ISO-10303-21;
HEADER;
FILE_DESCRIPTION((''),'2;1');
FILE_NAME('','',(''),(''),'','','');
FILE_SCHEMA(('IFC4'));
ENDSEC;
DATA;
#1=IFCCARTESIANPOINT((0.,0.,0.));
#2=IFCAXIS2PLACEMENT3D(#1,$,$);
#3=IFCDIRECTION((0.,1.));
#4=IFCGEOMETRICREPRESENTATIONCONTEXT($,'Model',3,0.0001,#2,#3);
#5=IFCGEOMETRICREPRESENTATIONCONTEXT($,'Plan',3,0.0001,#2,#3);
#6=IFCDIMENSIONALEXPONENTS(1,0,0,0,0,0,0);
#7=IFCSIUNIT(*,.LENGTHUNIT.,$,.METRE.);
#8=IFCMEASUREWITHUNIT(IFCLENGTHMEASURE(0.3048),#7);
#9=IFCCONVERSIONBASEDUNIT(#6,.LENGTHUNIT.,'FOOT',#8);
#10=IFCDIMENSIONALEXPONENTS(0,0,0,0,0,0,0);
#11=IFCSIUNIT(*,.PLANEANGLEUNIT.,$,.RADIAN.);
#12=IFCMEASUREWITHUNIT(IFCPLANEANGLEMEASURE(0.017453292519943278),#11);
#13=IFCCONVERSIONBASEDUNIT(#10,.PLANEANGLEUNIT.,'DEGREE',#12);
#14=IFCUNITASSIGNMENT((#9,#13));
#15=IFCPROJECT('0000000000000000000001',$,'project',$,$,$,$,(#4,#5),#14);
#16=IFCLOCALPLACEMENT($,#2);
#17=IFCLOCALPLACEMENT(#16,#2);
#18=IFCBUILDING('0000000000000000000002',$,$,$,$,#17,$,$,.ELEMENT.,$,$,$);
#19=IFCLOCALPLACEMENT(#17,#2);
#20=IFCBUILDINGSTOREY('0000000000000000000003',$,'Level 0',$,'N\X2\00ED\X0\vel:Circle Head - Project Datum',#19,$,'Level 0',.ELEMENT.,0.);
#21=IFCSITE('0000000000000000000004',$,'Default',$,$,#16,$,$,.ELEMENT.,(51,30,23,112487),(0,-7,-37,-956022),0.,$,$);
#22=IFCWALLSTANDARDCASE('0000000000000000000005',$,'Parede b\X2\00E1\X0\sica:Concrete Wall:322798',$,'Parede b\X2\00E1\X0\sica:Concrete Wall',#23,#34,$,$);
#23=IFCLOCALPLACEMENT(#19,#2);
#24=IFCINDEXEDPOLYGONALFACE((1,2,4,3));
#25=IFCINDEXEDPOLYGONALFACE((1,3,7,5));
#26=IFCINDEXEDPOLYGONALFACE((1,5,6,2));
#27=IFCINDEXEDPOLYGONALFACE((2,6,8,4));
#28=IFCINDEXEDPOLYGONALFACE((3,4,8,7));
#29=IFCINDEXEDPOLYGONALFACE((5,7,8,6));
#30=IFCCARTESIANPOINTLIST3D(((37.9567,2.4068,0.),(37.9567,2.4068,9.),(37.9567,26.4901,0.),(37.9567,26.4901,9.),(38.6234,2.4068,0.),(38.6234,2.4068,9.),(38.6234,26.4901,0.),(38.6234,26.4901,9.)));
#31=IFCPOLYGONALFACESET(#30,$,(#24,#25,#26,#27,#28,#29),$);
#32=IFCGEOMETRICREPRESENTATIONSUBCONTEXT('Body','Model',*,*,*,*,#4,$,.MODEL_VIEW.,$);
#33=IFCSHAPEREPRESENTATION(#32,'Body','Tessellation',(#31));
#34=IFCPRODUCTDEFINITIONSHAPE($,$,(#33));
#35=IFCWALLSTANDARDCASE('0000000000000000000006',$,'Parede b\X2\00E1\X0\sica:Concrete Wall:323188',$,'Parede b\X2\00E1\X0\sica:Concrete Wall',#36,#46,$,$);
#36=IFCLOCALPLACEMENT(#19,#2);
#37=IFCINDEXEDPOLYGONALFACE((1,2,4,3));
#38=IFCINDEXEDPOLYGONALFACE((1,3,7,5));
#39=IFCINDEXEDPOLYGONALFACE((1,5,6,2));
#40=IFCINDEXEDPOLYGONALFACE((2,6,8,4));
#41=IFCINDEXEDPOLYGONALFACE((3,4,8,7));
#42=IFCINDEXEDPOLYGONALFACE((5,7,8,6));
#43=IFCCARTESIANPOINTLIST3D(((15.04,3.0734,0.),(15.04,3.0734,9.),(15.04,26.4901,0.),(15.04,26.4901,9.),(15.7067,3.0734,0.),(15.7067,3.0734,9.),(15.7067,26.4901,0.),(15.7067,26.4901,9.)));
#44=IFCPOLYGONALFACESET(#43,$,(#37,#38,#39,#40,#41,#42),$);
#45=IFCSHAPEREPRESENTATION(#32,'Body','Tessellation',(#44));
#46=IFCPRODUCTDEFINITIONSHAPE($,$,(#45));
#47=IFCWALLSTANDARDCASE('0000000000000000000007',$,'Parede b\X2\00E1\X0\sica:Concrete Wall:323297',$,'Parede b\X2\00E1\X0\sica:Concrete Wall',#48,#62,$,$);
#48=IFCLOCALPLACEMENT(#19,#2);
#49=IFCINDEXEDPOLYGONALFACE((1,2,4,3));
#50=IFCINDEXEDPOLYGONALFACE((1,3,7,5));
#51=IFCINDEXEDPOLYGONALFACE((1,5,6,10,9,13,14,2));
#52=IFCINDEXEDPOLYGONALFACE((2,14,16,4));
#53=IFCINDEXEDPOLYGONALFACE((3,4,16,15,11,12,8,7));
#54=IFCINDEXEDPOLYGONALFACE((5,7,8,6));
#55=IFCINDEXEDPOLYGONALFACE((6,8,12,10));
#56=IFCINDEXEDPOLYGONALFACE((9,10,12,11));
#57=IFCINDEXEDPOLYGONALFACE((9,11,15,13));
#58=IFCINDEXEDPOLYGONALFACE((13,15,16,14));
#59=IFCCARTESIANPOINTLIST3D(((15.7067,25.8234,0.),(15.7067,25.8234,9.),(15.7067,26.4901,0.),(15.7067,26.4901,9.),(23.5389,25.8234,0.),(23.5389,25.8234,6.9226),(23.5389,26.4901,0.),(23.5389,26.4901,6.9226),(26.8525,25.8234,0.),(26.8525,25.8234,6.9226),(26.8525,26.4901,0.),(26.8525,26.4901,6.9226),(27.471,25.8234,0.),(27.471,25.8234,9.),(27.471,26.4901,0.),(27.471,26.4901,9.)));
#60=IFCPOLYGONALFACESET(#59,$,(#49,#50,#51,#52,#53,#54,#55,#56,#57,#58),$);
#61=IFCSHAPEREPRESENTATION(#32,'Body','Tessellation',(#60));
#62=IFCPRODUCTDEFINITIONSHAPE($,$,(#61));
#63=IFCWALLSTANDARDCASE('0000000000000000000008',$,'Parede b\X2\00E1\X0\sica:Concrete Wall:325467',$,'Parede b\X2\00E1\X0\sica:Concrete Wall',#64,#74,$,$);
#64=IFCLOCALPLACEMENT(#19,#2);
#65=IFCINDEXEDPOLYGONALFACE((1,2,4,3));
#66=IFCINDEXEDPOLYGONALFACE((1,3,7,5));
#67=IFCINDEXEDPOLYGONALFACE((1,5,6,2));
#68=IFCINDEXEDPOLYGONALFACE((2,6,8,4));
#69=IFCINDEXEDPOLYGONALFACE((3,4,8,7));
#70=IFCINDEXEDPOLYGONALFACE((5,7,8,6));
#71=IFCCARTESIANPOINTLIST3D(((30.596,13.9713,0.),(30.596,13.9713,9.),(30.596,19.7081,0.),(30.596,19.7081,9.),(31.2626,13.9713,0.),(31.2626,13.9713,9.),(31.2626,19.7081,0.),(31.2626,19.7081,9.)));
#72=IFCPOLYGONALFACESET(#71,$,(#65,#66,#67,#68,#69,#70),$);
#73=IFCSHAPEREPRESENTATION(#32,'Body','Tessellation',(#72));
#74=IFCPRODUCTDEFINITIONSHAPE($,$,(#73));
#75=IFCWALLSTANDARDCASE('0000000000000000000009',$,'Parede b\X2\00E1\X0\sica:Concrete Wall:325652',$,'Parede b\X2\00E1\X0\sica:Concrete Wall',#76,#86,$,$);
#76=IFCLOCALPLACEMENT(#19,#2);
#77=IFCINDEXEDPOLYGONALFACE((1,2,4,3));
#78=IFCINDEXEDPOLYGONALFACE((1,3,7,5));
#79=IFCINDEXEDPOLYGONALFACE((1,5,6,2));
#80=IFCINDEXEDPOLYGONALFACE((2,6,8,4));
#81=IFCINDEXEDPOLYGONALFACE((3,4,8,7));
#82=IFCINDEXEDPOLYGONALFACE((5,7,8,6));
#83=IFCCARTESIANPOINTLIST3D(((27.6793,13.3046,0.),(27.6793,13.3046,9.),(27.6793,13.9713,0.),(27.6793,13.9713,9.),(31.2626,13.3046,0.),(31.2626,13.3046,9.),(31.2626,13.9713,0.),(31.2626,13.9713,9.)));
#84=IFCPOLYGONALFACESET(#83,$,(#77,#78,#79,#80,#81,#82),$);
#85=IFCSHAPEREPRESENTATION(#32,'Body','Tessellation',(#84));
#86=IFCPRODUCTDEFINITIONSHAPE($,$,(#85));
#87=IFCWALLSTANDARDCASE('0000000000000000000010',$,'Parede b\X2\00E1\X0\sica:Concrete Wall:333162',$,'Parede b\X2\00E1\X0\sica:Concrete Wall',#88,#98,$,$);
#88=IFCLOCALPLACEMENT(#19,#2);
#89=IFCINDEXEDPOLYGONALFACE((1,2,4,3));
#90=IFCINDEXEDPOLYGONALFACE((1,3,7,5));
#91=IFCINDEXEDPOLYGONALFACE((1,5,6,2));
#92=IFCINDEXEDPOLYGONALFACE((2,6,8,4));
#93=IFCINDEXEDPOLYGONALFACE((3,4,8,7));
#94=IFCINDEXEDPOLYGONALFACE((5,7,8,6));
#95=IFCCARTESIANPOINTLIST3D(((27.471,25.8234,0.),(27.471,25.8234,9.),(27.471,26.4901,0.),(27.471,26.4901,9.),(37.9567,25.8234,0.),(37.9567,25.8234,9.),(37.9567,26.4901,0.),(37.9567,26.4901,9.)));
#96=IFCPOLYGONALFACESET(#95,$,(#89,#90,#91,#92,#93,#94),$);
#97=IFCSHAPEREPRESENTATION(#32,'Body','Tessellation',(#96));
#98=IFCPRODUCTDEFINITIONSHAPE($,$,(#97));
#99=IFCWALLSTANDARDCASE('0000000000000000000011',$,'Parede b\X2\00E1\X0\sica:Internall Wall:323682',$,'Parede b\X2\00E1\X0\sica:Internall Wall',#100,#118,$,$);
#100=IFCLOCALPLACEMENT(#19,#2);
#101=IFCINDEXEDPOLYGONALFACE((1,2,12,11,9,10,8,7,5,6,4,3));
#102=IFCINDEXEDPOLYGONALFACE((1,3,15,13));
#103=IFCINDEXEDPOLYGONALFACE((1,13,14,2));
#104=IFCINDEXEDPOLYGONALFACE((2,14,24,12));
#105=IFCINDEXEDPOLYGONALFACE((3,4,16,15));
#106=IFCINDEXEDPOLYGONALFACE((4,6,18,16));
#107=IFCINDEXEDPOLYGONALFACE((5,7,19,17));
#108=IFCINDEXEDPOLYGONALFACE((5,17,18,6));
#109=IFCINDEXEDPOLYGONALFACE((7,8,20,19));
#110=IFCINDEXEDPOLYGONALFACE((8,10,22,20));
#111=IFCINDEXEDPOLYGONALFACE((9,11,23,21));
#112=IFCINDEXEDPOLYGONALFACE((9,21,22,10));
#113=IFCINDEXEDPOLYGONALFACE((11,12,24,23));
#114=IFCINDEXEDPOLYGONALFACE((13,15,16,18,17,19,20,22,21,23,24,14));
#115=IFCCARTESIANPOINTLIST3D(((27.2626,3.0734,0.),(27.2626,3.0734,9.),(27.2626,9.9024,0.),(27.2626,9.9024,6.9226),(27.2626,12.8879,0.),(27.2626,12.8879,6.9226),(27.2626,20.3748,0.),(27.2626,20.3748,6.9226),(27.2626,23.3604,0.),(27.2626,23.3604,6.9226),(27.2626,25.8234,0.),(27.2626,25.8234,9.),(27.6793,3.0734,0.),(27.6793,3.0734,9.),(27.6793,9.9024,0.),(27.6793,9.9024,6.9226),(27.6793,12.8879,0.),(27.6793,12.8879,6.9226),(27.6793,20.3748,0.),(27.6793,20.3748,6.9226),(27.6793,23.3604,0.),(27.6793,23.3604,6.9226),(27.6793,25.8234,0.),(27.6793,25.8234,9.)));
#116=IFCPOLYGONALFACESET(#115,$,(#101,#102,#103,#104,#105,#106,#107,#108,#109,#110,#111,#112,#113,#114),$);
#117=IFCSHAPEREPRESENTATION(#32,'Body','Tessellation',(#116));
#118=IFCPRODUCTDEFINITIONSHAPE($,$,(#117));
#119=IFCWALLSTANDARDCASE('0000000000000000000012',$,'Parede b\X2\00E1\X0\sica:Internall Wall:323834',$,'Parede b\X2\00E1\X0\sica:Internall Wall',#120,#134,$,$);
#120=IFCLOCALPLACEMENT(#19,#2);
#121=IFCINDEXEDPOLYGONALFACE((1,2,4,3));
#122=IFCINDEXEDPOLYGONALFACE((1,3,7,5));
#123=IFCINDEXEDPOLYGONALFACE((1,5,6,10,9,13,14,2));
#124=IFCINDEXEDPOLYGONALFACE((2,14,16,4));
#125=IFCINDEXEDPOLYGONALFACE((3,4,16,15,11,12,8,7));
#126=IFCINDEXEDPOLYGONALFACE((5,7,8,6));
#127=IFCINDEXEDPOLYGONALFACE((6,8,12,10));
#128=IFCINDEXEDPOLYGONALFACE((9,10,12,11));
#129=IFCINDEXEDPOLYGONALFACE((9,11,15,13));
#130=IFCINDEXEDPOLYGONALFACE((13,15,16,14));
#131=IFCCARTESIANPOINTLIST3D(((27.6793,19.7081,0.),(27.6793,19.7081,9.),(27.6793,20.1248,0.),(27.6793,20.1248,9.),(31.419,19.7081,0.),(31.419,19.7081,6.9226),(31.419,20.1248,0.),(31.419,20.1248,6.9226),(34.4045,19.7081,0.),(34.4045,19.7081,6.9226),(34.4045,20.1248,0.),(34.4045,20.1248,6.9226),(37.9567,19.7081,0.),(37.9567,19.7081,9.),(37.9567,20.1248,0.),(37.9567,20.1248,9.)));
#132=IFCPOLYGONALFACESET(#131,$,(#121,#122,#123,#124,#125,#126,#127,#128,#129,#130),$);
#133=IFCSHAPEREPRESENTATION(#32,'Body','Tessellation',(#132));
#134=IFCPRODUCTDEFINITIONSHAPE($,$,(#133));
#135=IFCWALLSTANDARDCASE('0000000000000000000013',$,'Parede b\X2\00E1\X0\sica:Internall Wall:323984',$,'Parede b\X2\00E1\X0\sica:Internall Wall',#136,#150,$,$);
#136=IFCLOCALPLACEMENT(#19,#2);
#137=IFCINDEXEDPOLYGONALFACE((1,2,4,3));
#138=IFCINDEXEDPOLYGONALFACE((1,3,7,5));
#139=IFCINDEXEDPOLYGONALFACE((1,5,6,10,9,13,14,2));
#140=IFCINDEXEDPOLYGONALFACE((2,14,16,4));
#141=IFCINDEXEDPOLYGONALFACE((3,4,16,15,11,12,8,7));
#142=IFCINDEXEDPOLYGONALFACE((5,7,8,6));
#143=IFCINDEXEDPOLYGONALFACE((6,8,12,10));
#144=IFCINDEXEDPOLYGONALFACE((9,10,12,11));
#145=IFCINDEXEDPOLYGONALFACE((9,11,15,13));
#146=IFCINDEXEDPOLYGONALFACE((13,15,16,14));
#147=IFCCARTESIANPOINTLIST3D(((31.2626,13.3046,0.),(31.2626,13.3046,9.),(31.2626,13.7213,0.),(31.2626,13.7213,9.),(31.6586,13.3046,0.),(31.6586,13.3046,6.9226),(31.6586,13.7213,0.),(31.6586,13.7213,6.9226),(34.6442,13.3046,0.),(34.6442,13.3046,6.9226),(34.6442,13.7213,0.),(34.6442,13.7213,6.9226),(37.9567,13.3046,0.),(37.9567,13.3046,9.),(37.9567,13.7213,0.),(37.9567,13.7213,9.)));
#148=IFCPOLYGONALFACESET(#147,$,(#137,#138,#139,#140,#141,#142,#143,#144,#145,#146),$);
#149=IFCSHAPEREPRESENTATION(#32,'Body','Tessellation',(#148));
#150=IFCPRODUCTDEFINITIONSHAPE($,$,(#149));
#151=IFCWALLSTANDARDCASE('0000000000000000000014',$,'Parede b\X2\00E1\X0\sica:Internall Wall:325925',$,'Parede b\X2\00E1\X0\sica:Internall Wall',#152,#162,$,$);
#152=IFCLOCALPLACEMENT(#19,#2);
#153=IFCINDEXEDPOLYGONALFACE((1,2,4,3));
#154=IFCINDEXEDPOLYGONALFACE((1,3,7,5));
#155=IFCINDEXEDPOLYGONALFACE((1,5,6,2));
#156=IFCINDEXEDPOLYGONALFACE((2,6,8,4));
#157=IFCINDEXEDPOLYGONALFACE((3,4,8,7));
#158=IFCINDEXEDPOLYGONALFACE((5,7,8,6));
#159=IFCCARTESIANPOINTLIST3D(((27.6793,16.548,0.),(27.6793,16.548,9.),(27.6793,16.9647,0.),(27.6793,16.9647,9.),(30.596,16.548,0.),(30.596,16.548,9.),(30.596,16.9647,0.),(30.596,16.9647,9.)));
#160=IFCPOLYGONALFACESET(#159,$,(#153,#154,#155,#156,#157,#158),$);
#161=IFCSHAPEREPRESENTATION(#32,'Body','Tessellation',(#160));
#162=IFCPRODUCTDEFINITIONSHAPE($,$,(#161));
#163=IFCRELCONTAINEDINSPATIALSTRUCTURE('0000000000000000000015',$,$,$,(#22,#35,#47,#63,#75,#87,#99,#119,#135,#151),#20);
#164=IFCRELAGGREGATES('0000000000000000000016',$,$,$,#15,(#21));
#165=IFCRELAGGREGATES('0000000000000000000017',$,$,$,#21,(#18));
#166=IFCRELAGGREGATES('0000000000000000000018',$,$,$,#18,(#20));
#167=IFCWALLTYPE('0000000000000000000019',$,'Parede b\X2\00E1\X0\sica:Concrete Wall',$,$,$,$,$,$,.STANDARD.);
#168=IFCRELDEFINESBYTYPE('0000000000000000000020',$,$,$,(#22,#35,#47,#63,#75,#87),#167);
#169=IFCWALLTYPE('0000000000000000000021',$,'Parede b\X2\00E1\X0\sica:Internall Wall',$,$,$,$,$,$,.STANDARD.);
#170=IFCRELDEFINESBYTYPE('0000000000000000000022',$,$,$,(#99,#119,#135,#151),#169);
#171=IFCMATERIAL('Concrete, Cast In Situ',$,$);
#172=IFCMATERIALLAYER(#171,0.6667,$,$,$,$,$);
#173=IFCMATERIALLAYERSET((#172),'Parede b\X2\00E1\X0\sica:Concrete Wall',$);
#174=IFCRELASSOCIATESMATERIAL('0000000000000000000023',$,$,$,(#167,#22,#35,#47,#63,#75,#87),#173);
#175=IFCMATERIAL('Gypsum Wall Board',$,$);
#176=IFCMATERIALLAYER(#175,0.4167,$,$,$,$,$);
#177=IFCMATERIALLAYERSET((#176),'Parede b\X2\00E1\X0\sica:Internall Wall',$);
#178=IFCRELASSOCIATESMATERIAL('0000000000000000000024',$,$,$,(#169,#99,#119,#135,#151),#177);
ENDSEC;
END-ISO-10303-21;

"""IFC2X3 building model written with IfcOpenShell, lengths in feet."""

from ifc_helpers import new_model, entity, si_unit, converted_unit, direction, frame, frame_2d, origin, place, context, subcontext, project, spatial, rectangle, extrude, material, layer, layer_set, layer_usage, type_object, element, save


model = new_model("IFC2X3")

# Units and contexts
model_context = context("Model", 3, precision=0.0001, world=origin(), true_north=direction((0.0, 1.0)))
plan_context = context("Plan", 3, precision=0.0001, world=origin(), true_north=direction((0.0, 1.0)))
body_context = subcontext(model_context, "Body", "Model", "MODEL_VIEW")
ifc_project = project(units=[converted_unit("LENGTHUNIT", "FOOT", entity("IfcLengthMeasure", 0.3048), si_unit("LENGTHUNIT", "METRE"), dimensions=[1, 0, 0, 0, 0, 0, 0]), converted_unit("PLANEANGLEUNIT", "DEGREE", entity("IfcPlaneAngleMeasure", 0.017453292519943278), si_unit("PLANEANGLEUNIT", "RADIAN"), dimensions=[0, 0, 0, 0, 0, 0, 0])], contexts=[model_context, plan_context])

# Site, building, storey
site_placement = place(None, origin())
site = spatial("IfcSite", under=ifc_project, at=site_placement, Name="Default", CompositionType="ELEMENT", RefLatitude=(51, 30, 23, 112487), RefLongitude=(0, -7, -37, -956022), RefElevation=0.0)
building_placement = place(site_placement, origin())
building = spatial("IfcBuilding", under=site, at=building_placement, CompositionType="ELEMENT")
storey_placement = place(building_placement, origin())
storey = spatial("IfcBuildingStorey", under=building, at=storey_placement, Name="Level 0", ObjectType="Nível:Circle Head - Project Datum", LongName="Level 0", CompositionType="ELEMENT", Elevation=0.0)

# Wall
ifc_material_1 = material(Name="Concrete, Cast In Situ")
ifc_layer_1 = layer(ifc_material_1, 0.6667)
ifc_layer_set_1 = layer_set([ifc_layer_1], Name="Parede básica:Concrete Wall")
ifc_layer_usage_1 = layer_usage(ifc_layer_set_1, "AXIS2", "NEGATIVE", 0.3333)
wall_type_1 = type_object("IfcWallType", Name="Parede básica:Concrete Wall", PredefinedType="STANDARD", material=ifc_layer_set_1)
wall_1_placement = place(storey_placement, frame((38.29, 26.4901, 0.0), z_axis=(0.0, 0.0, 1.0), x_axis=(0.0, -1.0, 0.0)))
element("IfcWallStandardCase", 1, at=wall_1_placement, inside=storey, type_object=wall_type_1, material=ifc_layer_usage_1, Name="Parede básica:Concrete Wall:322798", ObjectType="Parede básica:Concrete Wall", context=body_context, shape_type="SweptSolid", body=[
    extrude(rectangle(XDim=24.0833, YDim=0.6667, at=frame_2d((12.0417, 0.0), x_axis=(-1.0, 0.0))), origin(), (0.0, 0.0, 1.0), 9.0),
])

# Wall
ifc_layer_usage_2 = layer_usage(ifc_layer_set_1, "AXIS2", "NEGATIVE", 0.3333)
wall_2_placement = place(storey_placement, frame((15.3734, 3.0734, 0.0), z_axis=(0.0, 0.0, 1.0), x_axis=(0.0, 1.0, 0.0)))
element("IfcWallStandardCase", 2, at=wall_2_placement, inside=storey, type_object=wall_type_1, material=ifc_layer_usage_2, Name="Parede básica:Concrete Wall:323188", ObjectType="Parede básica:Concrete Wall", context=body_context, shape_type="SweptSolid", body=[
    extrude(rectangle(XDim=23.4167, YDim=0.6667, at=frame_2d((11.7083, 0.0), x_axis=(-1.0, 0.0))), origin(), (0.0, 0.0, 1.0), 9.0),
])

# Wall, opening
ifc_layer_usage_3 = layer_usage(ifc_layer_set_1, "AXIS2", "NEGATIVE", 0.3333)
wall_3_placement = place(storey_placement, frame((15.7067, 26.1568, 0.0)))
wall_3 = element("IfcWallStandardCase", 3, at=wall_3_placement, inside=storey, type_object=wall_type_1, material=ifc_layer_usage_3, Name="Parede básica:Concrete Wall:323297", ObjectType="Parede básica:Concrete Wall", context=body_context, shape_type="SweptSolid", body=[
    extrude(rectangle(XDim=11.7643, YDim=0.6667, at=frame_2d((5.8821, 0.0), x_axis=(1.0, 0.0))), origin(), (0.0, 0.0, 1.0), 9.0),
])
opening_1_placement = place(wall_3_placement, frame((11.1458, 0.3333, 0.0)))
element("IfcOpeningElement", 4, at=opening_1_placement, cuts=wall_3, ObjectType="Opening", context=body_context, shape_type="SweptSolid", body=[
    extrude(rectangle(XDim=6.9226, YDim=3.3136, at=frame_2d((3.4613, 1.6568), x_axis=(1.0, 0.0))), frame((0.0, 0.0, 0.0), z_axis=(0.0, -1.0, 0.0), x_axis=(0.0, 0.0, 1.0)), (0.0, 0.0, 1.0), 0.6667),
])

# Walls
ifc_layer_usage_4 = layer_usage(ifc_layer_set_1, "AXIS2", "NEGATIVE", 0.3333)
wall_4_placement = place(storey_placement, frame((30.9293, 19.7081, 0.0), z_axis=(0.0, 0.0, 1.0), x_axis=(0.0, -1.0, 0.0)))
element("IfcWallStandardCase", 5, at=wall_4_placement, inside=storey, type_object=wall_type_1, material=ifc_layer_usage_4, Name="Parede básica:Concrete Wall:325467", ObjectType="Parede básica:Concrete Wall", context=body_context, shape_type="SweptSolid", body=[
    extrude(rectangle(XDim=5.7369, YDim=0.6667, at=frame_2d((2.8684, 0.0), x_axis=(-1.0, 0.0))), origin(), (0.0, 0.0, 1.0), 9.0),
])
ifc_layer_usage_5 = layer_usage(ifc_layer_set_1, "AXIS2", "NEGATIVE", 0.3333)
wall_5_placement = place(storey_placement, frame((31.2626, 13.6379, 0.0), z_axis=(0.0, 0.0, 1.0), x_axis=(-1.0, 0.0, 0.0)))
element("IfcWallStandardCase", 6, at=wall_5_placement, inside=storey, type_object=wall_type_1, material=ifc_layer_usage_5, Name="Parede básica:Concrete Wall:325652", ObjectType="Parede básica:Concrete Wall", context=body_context, shape_type="SweptSolid", body=[
    extrude(rectangle(XDim=3.5833, YDim=0.6667, at=frame_2d((1.7917, 0.0), x_axis=(-1.0, 0.0))), origin(), (0.0, 0.0, 1.0), 9.0),
])
ifc_layer_usage_6 = layer_usage(ifc_layer_set_1, "AXIS2", "NEGATIVE", 0.3333)
wall_6_placement = place(storey_placement, frame((27.471, 26.1568, 0.0)))
element("IfcWallStandardCase", 7, at=wall_6_placement, inside=storey, type_object=wall_type_1, material=ifc_layer_usage_6, Name="Parede básica:Concrete Wall:333162", ObjectType="Parede básica:Concrete Wall", context=body_context, shape_type="SweptSolid", body=[
    extrude(rectangle(XDim=10.4857, YDim=0.6667, at=frame_2d((5.2429, 0.0), x_axis=(-1.0, 0.0))), origin(), (0.0, 0.0, 1.0), 9.0),
])

# Wall, openings
ifc_material_2 = material(Name="Gypsum Wall Board")
ifc_layer_2 = layer(ifc_material_2, 0.4167)
ifc_layer_set_2 = layer_set([ifc_layer_2], Name="Parede básica:Internall Wall")
ifc_layer_usage_7 = layer_usage(ifc_layer_set_2, "AXIS2", "POSITIVE", -0.2083)
wall_type_2 = type_object("IfcWallType", Name="Parede básica:Internall Wall", PredefinedType="STANDARD", material=ifc_layer_set_2)
wall_7_placement = place(storey_placement, frame((27.471, 3.0734, 0.0), z_axis=(0.0, 0.0, 1.0), x_axis=(0.0, 1.0, 0.0)))
wall_7 = element("IfcWallStandardCase", 8, at=wall_7_placement, inside=storey, type_object=wall_type_2, material=ifc_layer_usage_7, Name="Parede básica:Internall Wall:323682", ObjectType="Parede básica:Internall Wall", context=body_context, shape_type="SweptSolid", body=[
    extrude(rectangle(XDim=22.75, YDim=0.4167, at=frame_2d((11.375, 0.0), x_axis=(1.0, 0.0))), origin(), (0.0, 0.0, 1.0), 9.0),
])
opening_2_placement = place(wall_7_placement, frame((20.2869, 0.2083, 0.0)))
element("IfcOpeningElement", 9, at=opening_2_placement, cuts=wall_7, ObjectType="Opening", context=body_context, shape_type="SweptSolid", body=[
    extrude(rectangle(XDim=6.9226, YDim=2.9856, at=frame_2d((3.4613, 1.4928), x_axis=(1.0, 0.0))), frame((0.0, 0.0, 0.0), z_axis=(0.0, -1.0, 0.0), x_axis=(0.0, 0.0, 1.0)), (0.0, 0.0, 1.0), 0.4167),
])
opening_3_placement = place(wall_7_placement, frame((9.8145, 0.2083, 0.0)))
element("IfcOpeningElement", 10, at=opening_3_placement, cuts=wall_7, ObjectType="Opening", context=body_context, shape_type="SweptSolid", body=[
    extrude(rectangle(XDim=6.9226, YDim=2.9856, at=frame_2d((3.4613, 1.4928), x_axis=(1.0, 0.0))), frame((0.0, 0.0, 0.0), z_axis=(0.0, -1.0, 0.0), x_axis=(0.0, 0.0, 1.0)), (0.0, 0.0, 1.0), 0.4167),
])

# Walls, openings
ifc_layer_usage_8 = layer_usage(ifc_layer_set_2, "AXIS2", "POSITIVE", -0.2083)
wall_8_placement = place(storey_placement, frame((37.9567, 19.9165, 0.0), z_axis=(0.0, 0.0, 1.0), x_axis=(-1.0, 0.0, 0.0)))
wall_8 = element("IfcWallStandardCase", 11, at=wall_8_placement, inside=storey, type_object=wall_type_2, material=ifc_layer_usage_8, Name="Parede básica:Internall Wall:323834", ObjectType="Parede básica:Internall Wall", context=body_context, shape_type="SweptSolid", body=[
    extrude(rectangle(XDim=10.2774, YDim=0.4167, at=frame_2d((5.1387, 0.0), x_axis=(1.0, 0.0))), origin(), (0.0, 0.0, 1.0), 9.0),
])
opening_4_placement = place(wall_8_placement, frame((3.5522, -0.2083, 0.0)))
element("IfcOpeningElement", 12, at=opening_4_placement, cuts=wall_8, ObjectType="Opening", context=body_context, shape_type="SweptSolid", body=[
    extrude(rectangle(XDim=6.9226, YDim=2.9856, at=frame_2d((3.4613, 1.4928), x_axis=(1.0, 0.0))), frame((0.0, 0.0, 0.0), z_axis=(0.0, 1.0, 0.0), x_axis=(0.0, 0.0, 1.0)), (0.0, 0.0, 1.0), 0.4167),
])
ifc_layer_usage_9 = layer_usage(ifc_layer_set_2, "AXIS2", "NEGATIVE", 0.2083)
wall_9_placement = place(storey_placement, frame((37.9567, 13.5129, 0.0), z_axis=(0.0, 0.0, 1.0), x_axis=(-1.0, 0.0, 0.0)))
wall_9 = element("IfcWallStandardCase", 13, at=wall_9_placement, inside=storey, type_object=wall_type_2, material=ifc_layer_usage_9, Name="Parede básica:Internall Wall:323984", ObjectType="Parede básica:Internall Wall", context=body_context, shape_type="SweptSolid", body=[
    extrude(rectangle(XDim=6.6941, YDim=0.4167, at=frame_2d((3.347, 0.0), x_axis=(1.0, 0.0))), origin(), (0.0, 0.0, 1.0), 9.0),
])
opening_5_placement = place(wall_9_placement, frame((6.2981, 0.2083, 0.0)))
element("IfcOpeningElement", 14, at=opening_5_placement, cuts=wall_9, ObjectType="Opening", context=body_context, shape_type="SweptSolid", body=[
    extrude(rectangle(XDim=6.9226, YDim=2.9856, at=frame_2d((3.4613, 1.4928), x_axis=(1.0, 0.0))), frame((0.0, 0.0, 0.0), z_axis=(0.0, -1.0, 0.0), x_axis=(0.0, 0.0, 1.0)), (0.0, 0.0, 1.0), 0.4167),
])

# Wall
ifc_layer_usage_10 = layer_usage(ifc_layer_set_2, "AXIS2", "NEGATIVE", 0.2083)
wall_10_placement = place(storey_placement, frame((27.6793, 16.7564, 0.0)))
element("IfcWallStandardCase", 15, at=wall_10_placement, inside=storey, type_object=wall_type_2, material=ifc_layer_usage_10, Name="Parede básica:Internall Wall:325925", ObjectType="Parede básica:Internall Wall", context=body_context, shape_type="SweptSolid", body=[
    extrude(rectangle(XDim=2.9167, YDim=0.4167, at=frame_2d((1.4583, 0.0), x_axis=(-1.0, 0.0))), origin(), (0.0, 0.0, 1.0), 9.0),
])

save(model, "model.ifc")
